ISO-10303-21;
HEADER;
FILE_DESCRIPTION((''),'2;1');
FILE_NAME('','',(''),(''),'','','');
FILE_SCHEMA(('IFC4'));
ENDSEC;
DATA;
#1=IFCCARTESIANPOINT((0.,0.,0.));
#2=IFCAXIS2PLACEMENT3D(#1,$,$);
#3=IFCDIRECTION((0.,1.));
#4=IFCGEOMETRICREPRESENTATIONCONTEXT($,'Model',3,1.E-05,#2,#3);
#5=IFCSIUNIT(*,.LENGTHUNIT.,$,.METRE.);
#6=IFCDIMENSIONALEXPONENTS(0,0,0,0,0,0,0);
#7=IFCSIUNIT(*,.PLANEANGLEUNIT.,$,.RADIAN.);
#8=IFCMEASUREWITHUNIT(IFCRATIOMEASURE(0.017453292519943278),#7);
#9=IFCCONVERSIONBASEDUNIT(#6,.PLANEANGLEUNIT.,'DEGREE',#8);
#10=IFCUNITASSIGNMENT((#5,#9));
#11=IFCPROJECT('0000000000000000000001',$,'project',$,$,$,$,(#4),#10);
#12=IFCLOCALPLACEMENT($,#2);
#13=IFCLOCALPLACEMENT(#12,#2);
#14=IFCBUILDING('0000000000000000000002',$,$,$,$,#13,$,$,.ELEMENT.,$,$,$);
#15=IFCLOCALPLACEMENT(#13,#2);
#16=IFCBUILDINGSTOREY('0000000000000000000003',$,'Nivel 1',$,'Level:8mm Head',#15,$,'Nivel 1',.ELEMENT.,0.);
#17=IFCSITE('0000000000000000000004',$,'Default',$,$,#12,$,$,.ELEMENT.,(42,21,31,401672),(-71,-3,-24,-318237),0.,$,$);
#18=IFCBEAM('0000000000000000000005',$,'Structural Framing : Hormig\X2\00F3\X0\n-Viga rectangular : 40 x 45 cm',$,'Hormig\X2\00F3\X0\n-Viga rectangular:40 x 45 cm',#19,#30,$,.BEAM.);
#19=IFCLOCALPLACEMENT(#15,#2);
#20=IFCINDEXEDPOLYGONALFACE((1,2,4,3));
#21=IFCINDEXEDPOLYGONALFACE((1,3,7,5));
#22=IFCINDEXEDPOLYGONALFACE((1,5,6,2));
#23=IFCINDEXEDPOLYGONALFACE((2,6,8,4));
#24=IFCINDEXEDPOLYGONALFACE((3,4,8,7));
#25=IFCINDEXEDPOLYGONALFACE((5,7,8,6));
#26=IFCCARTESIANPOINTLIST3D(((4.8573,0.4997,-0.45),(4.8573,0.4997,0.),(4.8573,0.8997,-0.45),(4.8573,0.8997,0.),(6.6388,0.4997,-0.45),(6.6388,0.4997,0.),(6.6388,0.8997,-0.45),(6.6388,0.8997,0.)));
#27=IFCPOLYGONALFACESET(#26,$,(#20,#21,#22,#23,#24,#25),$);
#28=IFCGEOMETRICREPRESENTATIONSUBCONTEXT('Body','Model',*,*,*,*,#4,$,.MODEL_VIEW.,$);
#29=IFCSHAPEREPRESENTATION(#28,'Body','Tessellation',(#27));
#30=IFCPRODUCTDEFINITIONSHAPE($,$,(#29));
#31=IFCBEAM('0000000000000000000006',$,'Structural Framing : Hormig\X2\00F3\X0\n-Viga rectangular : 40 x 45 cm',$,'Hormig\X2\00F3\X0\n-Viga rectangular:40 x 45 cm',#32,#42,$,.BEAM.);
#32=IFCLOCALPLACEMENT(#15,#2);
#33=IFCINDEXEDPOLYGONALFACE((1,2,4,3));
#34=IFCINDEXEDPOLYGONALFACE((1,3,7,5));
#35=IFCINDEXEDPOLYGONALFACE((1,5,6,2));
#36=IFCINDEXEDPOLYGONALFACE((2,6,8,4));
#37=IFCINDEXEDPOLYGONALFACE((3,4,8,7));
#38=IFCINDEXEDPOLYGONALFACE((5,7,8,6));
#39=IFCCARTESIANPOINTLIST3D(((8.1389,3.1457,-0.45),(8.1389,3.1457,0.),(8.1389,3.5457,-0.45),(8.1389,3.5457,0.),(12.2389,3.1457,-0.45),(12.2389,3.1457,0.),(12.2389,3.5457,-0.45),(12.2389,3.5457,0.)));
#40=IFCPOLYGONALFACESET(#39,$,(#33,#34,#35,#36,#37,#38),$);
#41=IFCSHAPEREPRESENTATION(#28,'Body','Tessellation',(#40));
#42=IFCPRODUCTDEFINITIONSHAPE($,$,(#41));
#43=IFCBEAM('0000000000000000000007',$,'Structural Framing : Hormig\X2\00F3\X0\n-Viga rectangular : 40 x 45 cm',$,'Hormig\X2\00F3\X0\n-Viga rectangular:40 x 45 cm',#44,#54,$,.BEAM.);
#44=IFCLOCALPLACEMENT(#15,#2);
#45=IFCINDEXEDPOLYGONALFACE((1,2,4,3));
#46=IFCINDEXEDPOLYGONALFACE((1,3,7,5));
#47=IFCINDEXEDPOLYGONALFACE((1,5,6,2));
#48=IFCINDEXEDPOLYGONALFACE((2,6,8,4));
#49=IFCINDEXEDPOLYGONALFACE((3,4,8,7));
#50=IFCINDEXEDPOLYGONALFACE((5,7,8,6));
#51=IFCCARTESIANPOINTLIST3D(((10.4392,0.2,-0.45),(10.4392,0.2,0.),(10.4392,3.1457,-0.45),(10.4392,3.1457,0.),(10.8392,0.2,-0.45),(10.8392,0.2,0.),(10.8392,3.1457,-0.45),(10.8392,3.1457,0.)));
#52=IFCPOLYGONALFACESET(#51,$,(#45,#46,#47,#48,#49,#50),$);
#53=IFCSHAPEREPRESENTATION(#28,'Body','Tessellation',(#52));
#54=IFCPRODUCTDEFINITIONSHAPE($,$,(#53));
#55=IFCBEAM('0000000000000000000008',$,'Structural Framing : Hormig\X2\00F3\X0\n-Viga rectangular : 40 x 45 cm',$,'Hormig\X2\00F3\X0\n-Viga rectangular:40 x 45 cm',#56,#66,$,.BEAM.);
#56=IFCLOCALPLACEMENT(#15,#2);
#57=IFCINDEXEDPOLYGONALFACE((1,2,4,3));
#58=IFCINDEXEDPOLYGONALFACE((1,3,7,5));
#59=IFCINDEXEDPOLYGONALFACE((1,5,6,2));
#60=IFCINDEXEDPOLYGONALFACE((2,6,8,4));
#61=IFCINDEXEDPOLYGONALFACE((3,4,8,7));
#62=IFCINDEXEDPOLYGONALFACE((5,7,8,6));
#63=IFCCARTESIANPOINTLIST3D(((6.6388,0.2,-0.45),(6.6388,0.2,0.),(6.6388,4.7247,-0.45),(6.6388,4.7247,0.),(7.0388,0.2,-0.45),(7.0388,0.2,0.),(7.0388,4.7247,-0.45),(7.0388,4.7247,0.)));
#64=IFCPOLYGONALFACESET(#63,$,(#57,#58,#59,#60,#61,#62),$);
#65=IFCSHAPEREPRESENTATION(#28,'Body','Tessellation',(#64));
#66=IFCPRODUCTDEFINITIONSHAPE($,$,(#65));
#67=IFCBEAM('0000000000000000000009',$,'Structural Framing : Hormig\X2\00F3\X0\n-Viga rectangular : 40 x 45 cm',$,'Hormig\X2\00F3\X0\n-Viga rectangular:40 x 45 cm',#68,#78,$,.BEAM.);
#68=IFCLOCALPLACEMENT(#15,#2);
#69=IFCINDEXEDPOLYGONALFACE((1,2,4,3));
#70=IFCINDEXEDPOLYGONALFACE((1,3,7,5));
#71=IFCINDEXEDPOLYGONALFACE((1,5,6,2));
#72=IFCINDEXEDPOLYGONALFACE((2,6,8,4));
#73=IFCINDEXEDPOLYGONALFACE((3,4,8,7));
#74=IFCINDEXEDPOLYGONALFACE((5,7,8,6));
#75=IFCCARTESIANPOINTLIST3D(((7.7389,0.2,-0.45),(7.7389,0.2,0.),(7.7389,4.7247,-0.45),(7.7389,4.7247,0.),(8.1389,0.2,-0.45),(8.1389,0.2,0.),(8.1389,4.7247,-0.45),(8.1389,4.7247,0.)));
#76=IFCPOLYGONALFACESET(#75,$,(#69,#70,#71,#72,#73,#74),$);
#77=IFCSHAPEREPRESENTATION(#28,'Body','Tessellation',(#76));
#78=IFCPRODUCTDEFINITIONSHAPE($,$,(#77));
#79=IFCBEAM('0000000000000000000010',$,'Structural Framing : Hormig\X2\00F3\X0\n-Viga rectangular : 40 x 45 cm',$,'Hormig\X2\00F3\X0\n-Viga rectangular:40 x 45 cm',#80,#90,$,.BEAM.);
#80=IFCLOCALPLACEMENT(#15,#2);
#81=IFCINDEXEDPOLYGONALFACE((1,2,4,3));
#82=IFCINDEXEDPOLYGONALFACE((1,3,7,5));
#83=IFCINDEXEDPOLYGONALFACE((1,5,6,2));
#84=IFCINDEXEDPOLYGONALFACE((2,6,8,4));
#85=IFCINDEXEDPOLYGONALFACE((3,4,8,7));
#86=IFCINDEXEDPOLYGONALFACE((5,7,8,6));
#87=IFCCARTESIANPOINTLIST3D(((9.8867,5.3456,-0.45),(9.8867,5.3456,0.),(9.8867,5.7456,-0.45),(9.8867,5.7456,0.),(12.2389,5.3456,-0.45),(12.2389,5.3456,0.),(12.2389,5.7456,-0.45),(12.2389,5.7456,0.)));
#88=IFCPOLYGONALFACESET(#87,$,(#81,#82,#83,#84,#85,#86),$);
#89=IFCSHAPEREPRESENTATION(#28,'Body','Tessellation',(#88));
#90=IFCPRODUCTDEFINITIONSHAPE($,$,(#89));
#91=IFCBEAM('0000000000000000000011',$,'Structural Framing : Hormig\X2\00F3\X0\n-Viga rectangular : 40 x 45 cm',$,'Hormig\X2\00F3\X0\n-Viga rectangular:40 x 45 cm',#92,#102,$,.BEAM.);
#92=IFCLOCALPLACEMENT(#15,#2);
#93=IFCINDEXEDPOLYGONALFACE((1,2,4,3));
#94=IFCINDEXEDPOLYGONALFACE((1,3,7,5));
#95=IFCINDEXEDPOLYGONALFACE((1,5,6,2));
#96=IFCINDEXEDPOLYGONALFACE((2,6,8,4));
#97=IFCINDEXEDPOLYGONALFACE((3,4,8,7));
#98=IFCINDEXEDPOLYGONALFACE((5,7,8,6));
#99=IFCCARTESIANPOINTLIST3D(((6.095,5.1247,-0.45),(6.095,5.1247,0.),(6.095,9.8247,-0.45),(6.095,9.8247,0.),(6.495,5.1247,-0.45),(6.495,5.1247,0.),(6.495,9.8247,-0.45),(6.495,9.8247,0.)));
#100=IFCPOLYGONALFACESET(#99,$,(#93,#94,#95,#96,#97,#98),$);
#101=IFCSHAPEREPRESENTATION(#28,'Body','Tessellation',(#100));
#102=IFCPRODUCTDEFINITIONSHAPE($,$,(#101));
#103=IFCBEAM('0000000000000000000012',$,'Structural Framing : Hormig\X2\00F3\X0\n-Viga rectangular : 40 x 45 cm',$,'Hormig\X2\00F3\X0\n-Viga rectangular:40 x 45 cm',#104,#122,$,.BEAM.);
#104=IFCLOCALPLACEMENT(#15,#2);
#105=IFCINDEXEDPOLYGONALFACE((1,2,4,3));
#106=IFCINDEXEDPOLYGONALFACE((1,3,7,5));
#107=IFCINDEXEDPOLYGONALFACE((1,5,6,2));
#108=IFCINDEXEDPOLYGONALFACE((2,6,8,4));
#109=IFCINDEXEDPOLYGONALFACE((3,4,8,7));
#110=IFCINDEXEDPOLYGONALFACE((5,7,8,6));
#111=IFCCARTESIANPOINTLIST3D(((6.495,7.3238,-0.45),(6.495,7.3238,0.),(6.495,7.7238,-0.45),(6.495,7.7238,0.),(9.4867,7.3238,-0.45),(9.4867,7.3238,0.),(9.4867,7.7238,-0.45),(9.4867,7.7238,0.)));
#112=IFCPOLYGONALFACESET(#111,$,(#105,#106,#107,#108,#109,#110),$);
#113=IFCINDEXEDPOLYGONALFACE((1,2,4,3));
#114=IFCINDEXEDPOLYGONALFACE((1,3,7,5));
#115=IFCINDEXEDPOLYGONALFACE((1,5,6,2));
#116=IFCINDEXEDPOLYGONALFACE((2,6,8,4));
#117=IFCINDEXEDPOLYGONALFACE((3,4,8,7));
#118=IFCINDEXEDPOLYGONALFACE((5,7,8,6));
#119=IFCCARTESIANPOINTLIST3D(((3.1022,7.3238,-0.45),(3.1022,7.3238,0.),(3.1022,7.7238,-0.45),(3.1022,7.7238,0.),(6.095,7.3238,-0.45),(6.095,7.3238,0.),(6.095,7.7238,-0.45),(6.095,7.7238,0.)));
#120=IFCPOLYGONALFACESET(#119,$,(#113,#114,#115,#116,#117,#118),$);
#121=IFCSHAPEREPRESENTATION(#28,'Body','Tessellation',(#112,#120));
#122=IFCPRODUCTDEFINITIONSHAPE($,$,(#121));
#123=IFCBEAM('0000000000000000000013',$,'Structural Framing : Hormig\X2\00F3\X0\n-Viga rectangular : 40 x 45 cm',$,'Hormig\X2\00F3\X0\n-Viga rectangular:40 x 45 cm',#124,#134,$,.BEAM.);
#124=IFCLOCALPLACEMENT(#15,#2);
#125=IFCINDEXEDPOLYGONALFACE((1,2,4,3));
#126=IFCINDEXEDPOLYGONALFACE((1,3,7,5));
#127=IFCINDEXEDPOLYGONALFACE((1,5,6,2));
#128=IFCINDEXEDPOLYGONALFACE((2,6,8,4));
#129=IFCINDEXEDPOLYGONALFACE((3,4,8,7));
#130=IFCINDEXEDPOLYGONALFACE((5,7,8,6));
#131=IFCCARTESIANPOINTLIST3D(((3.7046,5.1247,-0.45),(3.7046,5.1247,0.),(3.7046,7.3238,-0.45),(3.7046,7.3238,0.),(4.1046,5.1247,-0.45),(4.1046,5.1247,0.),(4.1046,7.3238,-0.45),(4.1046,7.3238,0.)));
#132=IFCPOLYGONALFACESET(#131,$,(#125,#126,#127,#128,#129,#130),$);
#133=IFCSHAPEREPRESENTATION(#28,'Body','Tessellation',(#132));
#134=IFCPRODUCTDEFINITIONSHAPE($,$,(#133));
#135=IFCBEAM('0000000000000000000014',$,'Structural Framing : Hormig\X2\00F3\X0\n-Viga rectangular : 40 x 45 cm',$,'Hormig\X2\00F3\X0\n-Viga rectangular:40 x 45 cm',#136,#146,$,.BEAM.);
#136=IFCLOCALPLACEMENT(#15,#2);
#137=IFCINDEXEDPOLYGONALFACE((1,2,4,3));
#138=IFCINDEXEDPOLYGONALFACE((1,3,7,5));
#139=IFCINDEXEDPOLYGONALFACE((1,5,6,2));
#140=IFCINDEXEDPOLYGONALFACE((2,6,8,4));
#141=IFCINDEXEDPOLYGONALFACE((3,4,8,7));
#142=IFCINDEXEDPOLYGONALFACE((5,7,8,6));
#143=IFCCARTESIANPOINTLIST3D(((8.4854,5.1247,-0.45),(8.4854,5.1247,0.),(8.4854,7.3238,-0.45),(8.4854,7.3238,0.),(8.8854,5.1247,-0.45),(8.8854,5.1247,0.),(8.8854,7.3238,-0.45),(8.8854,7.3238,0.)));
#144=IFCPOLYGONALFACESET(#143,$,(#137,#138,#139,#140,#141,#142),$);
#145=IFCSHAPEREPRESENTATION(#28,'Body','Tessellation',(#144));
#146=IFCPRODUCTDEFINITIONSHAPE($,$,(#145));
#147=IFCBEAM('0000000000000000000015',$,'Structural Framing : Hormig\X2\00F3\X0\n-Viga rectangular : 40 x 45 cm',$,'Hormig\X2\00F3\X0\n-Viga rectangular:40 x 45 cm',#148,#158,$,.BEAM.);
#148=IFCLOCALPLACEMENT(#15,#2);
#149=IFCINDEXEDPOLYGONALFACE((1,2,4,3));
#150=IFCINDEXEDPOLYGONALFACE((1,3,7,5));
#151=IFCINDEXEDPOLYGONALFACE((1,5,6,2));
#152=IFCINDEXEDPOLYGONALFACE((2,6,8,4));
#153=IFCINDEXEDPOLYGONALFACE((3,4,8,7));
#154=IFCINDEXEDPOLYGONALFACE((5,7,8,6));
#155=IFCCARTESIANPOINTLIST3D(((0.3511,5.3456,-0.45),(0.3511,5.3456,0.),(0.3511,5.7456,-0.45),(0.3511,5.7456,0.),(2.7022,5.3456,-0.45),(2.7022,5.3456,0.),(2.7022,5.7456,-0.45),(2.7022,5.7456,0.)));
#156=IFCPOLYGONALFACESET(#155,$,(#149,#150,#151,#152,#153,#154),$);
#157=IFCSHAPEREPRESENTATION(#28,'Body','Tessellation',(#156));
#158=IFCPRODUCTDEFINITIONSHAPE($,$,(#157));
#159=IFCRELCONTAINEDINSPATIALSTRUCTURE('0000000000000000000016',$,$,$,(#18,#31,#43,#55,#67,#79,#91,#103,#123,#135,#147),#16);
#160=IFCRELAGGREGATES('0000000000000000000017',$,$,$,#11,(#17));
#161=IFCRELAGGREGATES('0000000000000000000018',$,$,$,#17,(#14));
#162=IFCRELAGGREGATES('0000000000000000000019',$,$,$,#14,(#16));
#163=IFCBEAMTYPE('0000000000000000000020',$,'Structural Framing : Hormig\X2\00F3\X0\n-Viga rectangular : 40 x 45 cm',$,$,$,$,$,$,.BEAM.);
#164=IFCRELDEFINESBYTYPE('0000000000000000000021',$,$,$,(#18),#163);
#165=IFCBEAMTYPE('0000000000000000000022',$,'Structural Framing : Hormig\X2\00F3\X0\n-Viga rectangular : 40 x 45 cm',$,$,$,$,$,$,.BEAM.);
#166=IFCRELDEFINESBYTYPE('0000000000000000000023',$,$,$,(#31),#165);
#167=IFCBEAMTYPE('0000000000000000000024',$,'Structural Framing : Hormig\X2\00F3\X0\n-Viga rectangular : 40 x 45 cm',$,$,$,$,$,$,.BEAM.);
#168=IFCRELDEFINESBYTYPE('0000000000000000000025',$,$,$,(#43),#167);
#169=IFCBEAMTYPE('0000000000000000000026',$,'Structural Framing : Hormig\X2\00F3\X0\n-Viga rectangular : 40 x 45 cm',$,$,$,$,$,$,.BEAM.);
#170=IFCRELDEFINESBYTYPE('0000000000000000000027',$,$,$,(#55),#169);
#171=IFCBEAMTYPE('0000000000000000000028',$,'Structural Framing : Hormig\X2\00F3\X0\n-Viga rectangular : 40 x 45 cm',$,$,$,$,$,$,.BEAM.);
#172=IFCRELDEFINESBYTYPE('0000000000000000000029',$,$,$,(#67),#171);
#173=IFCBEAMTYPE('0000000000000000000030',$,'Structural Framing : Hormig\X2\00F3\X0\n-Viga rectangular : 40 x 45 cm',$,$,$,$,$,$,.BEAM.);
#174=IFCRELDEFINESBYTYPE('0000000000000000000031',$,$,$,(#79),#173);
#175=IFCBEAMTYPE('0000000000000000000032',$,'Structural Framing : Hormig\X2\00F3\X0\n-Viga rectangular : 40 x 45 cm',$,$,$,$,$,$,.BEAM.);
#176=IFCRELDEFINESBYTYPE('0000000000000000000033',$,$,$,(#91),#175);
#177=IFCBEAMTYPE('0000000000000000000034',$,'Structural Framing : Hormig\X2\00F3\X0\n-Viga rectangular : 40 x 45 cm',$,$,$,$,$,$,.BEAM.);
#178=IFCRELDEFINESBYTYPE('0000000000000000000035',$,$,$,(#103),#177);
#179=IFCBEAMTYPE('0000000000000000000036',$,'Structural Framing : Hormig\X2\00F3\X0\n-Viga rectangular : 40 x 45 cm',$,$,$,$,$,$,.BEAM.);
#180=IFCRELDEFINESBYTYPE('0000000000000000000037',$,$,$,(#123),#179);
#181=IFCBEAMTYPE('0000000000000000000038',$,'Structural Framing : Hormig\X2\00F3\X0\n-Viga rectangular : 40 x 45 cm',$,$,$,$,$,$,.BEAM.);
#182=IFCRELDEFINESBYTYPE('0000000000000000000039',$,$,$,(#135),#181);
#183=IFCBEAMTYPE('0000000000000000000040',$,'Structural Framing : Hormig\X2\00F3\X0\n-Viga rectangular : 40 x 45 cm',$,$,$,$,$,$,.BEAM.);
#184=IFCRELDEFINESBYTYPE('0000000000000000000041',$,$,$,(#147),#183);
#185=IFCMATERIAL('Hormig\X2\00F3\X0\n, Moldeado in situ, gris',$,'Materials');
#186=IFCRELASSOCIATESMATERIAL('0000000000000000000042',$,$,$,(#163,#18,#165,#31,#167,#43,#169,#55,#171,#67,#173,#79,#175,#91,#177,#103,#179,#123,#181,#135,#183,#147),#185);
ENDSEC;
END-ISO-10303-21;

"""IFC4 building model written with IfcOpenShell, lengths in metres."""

from ifc_helpers import new_model, entity, si_unit, converted_unit, direction, frame, origin, place, context, subcontext, project, spatial, indexed_curve, outline, extrude, source, transform, mapped, material, type_object, type_shapes, element, save


model = new_model("IFC4")

# Units and contexts
model_context = context("Model", 3, precision=1e-05, world=origin(), true_north=direction((0.0, 1.0)))
body_context = subcontext(model_context, "Body", "Model", "MODEL_VIEW")
ifc_project = project(units=[si_unit("LENGTHUNIT", "METRE"), converted_unit("PLANEANGLEUNIT", "DEGREE", entity("IfcRatioMeasure", 0.017453292519943278), si_unit("PLANEANGLEUNIT", "RADIAN"), dimensions=[0, 0, 0, 0, 0, 0, 0])], contexts=[model_context])

# Site, building, storey
site_placement = place(None, origin())
site = spatial("IfcSite", under=ifc_project, at=site_placement, Name="Default", CompositionType="ELEMENT", RefLatitude=(42, 21, 31, 401672), RefLongitude=(-71, -3, -24, -318237), RefElevation=0.0)
building_placement = place(site_placement, origin())
building = spatial("IfcBuilding", under=site, at=building_placement, CompositionType="ELEMENT")
storey_placement = place(building_placement, origin())
storey = spatial("IfcBuildingStorey", under=building, at=storey_placement, Name="Nivel 1", ObjectType="Level:8mm Head", LongName="Nivel 1", CompositionType="ELEMENT", Elevation=0.0)

# Beams
ifc_material_1 = material(Name="Hormigón, Moldeado in situ, gris", Category="Materials")
beam_type_1 = type_object("IfcBeamType", Name="Structural Framing : Hormigón-Viga rectangular : 40 x 45 cm", PredefinedType="BEAM", material=ifc_material_1)
shared_shape_1 = source(origin(), body_context, "Body", "SweptSolid", [
    extrude(outline(indexed_curve([(-0.225, -0.2), (0.225, -0.2), (0.225, 0.2), (-0.225, 0.2), (-0.225, -0.2)], self_intersect=False)), frame((4.8573, 0.6997, -0.225), z_axis=(1.0, 0.0, 0.0), x_axis=(0.0, 0.0, -1.0)), (0.0, 0.0, 1.0), 1.7816),
])
type_shapes(beam_type_1, [shared_shape_1])
beam_1_placement = place(storey_placement, origin())
element("IfcBeam", 1, at=beam_1_placement, inside=storey, type_object=beam_type_1, material=ifc_material_1, Name="Structural Framing : Hormigón-Viga rectangular : 40 x 45 cm", ObjectType="Hormigón-Viga rectangular:40 x 45 cm", PredefinedType="BEAM", context=body_context, shape_type="MappedRepresentation", body=[
    mapped(shared_shape_1, transform((0.0, 0.0, 0.0), scale=1.0)),
])
beam_type_2 = type_object("IfcBeamType", Name="Structural Framing : Hormigón-Viga rectangular : 40 x 45 cm", PredefinedType="BEAM", material=ifc_material_1)
shared_shape_2 = source(origin(), body_context, "Body", "SweptSolid", [
    extrude(outline(indexed_curve([(-0.225, -0.2), (0.225, -0.2), (0.225, 0.2), (-0.225, 0.2), (-0.225, -0.2)], self_intersect=False)), frame((8.1389, 3.3457, -0.225), z_axis=(1.0, 0.0, 0.0), x_axis=(0.0, 0.0, -1.0)), (0.0, 0.0, 1.0), 4.1),
])
type_shapes(beam_type_2, [shared_shape_2])
beam_2_placement = place(storey_placement, origin())
element("IfcBeam", 2, at=beam_2_placement, inside=storey, type_object=beam_type_2, material=ifc_material_1, Name="Structural Framing : Hormigón-Viga rectangular : 40 x 45 cm", ObjectType="Hormigón-Viga rectangular:40 x 45 cm", PredefinedType="BEAM", context=body_context, shape_type="MappedRepresentation", body=[
    mapped(shared_shape_2, transform((0.0, 0.0, 0.0), scale=1.0)),
])
beam_type_3 = type_object("IfcBeamType", Name="Structural Framing : Hormigón-Viga rectangular : 40 x 45 cm", PredefinedType="BEAM", material=ifc_material_1)
shared_shape_3 = source(origin(), body_context, "Body", "SweptSolid", [
    extrude(outline(indexed_curve([(-0.2, -0.225), (0.2, -0.225), (0.2, 0.225), (-0.2, 0.225), (-0.2, -0.225)], self_intersect=False)), frame((10.6392, 3.1457, -0.225), z_axis=(0.0, -1.0, 0.0), x_axis=(-1.0, 0.0, 0.0)), (0.0, 0.0, 1.0), 2.9457),
])
type_shapes(beam_type_3, [shared_shape_3])
beam_3_placement = place(storey_placement, origin())
element("IfcBeam", 3, at=beam_3_placement, inside=storey, type_object=beam_type_3, material=ifc_material_1, Name="Structural Framing : Hormigón-Viga rectangular : 40 x 45 cm", ObjectType="Hormigón-Viga rectangular:40 x 45 cm", PredefinedType="BEAM", context=body_context, shape_type="MappedRepresentation", body=[
    mapped(shared_shape_3, transform((0.0, 0.0, 0.0), scale=1.0)),
])
beam_type_4 = type_object("IfcBeamType", Name="Structural Framing : Hormigón-Viga rectangular : 40 x 45 cm", PredefinedType="BEAM", material=ifc_material_1)
shared_shape_4 = source(origin(), body_context, "Body", "SweptSolid", [
    extrude(outline(indexed_curve([(-0.2, -0.225), (0.2, -0.225), (0.2, 0.225), (-0.2, 0.225), (-0.2, -0.225)], self_intersect=False)), frame((6.8388, 4.7247, -0.225), z_axis=(0.0, -1.0, 0.0), x_axis=(-1.0, 0.0, 0.0)), (0.0, 0.0, 1.0), 4.5247),
])
type_shapes(beam_type_4, [shared_shape_4])
beam_4_placement = place(storey_placement, origin())
element("IfcBeam", 4, at=beam_4_placement, inside=storey, type_object=beam_type_4, material=ifc_material_1, Name="Structural Framing : Hormigón-Viga rectangular : 40 x 45 cm", ObjectType="Hormigón-Viga rectangular:40 x 45 cm", PredefinedType="BEAM", context=body_context, shape_type="MappedRepresentation", body=[
    mapped(shared_shape_4, transform((0.0, 0.0, 0.0), scale=1.0)),
])
beam_type_5 = type_object("IfcBeamType", Name="Structural Framing : Hormigón-Viga rectangular : 40 x 45 cm", PredefinedType="BEAM", material=ifc_material_1)
shared_shape_5 = source(origin(), body_context, "Body", "SweptSolid", [
    extrude(outline(indexed_curve([(-0.2, -0.225), (0.2, -0.225), (0.2, 0.225), (-0.2, 0.225), (-0.2, -0.225)], self_intersect=False)), frame((7.9389, 4.7247, -0.225), z_axis=(0.0, -1.0, 0.0), x_axis=(-1.0, 0.0, 0.0)), (0.0, 0.0, 1.0), 4.5247),
])
type_shapes(beam_type_5, [shared_shape_5])
beam_5_placement = place(storey_placement, origin())
element("IfcBeam", 5, at=beam_5_placement, inside=storey, type_object=beam_type_5, material=ifc_material_1, Name="Structural Framing : Hormigón-Viga rectangular : 40 x 45 cm", ObjectType="Hormigón-Viga rectangular:40 x 45 cm", PredefinedType="BEAM", context=body_context, shape_type="MappedRepresentation", body=[
    mapped(shared_shape_5, transform((0.0, 0.0, 0.0), scale=1.0)),
])
beam_type_6 = type_object("IfcBeamType", Name="Structural Framing : Hormigón-Viga rectangular : 40 x 45 cm", PredefinedType="BEAM", material=ifc_material_1)
shared_shape_6 = source(origin(), body_context, "Body", "SweptSolid", [
    extrude(outline(indexed_curve([(-0.225, -0.2), (0.225, -0.2), (0.225, 0.2), (-0.225, 0.2), (-0.225, -0.2)], self_intersect=False)), frame((9.8867, 5.5456, -0.225), z_axis=(1.0, 0.0, 0.0), x_axis=(0.0, 0.0, -1.0)), (0.0, 0.0, 1.0), 2.3522),
])
type_shapes(beam_type_6, [shared_shape_6])
beam_6_placement = place(storey_placement, origin())
element("IfcBeam", 6, at=beam_6_placement, inside=storey, type_object=beam_type_6, material=ifc_material_1, Name="Structural Framing : Hormigón-Viga rectangular : 40 x 45 cm", ObjectType="Hormigón-Viga rectangular:40 x 45 cm", PredefinedType="BEAM", context=body_context, shape_type="MappedRepresentation", body=[
    mapped(shared_shape_6, transform((0.0, 0.0, 0.0), scale=1.0)),
])
beam_type_7 = type_object("IfcBeamType", Name="Structural Framing : Hormigón-Viga rectangular : 40 x 45 cm", PredefinedType="BEAM", material=ifc_material_1)
shared_shape_7 = source(origin(), body_context, "Body", "SweptSolid", [
    extrude(outline(indexed_curve([(-0.2, -0.225), (0.2, -0.225), (0.2, 0.225), (-0.2, 0.225), (-0.2, -0.225)], self_intersect=False)), frame((6.295, 9.8247, -0.225), z_axis=(0.0, -1.0, 0.0), x_axis=(-1.0, 0.0, 0.0)), (0.0, 0.0, 1.0), 4.7001),
])
type_shapes(beam_type_7, [shared_shape_7])
beam_7_placement = place(storey_placement, origin())
element("IfcBeam", 7, at=beam_7_placement, inside=storey, type_object=beam_type_7, material=ifc_material_1, Name="Structural Framing : Hormigón-Viga rectangular : 40 x 45 cm", ObjectType="Hormigón-Viga rectangular:40 x 45 cm", PredefinedType="BEAM", context=body_context, shape_type="MappedRepresentation", body=[
    mapped(shared_shape_7, transform((0.0, 0.0, 0.0), scale=1.0)),
])
beam_type_8 = type_object("IfcBeamType", Name="Structural Framing : Hormigón-Viga rectangular : 40 x 45 cm", PredefinedType="BEAM", material=ifc_material_1)
shared_shape_8 = source(origin(), body_context, "Body", "SweptSolid", [
    extrude(outline(indexed_curve([(-0.225, -0.2), (0.225, -0.2), (0.225, 0.2), (-0.225, 0.2), (-0.225, -0.2)], self_intersect=False)), frame((6.495, 7.5238, -0.225), z_axis=(1.0, 0.0, 0.0), x_axis=(0.0, 0.0, -1.0)), (0.0, 0.0, 1.0), 2.9917),
    extrude(outline(indexed_curve([(-0.225, -0.2), (0.225, -0.2), (0.225, 0.2), (-0.225, 0.2), (-0.225, -0.2)], self_intersect=False)), frame((3.1022, 7.5238, -0.225), z_axis=(1.0, 0.0, 0.0), x_axis=(0.0, 0.0, -1.0)), (0.0, 0.0, 1.0), 2.9928),
])
type_shapes(beam_type_8, [shared_shape_8])
beam_8_placement = place(storey_placement, origin())
element("IfcBeam", 8, at=beam_8_placement, inside=storey, type_object=beam_type_8, material=ifc_material_1, Name="Structural Framing : Hormigón-Viga rectangular : 40 x 45 cm", ObjectType="Hormigón-Viga rectangular:40 x 45 cm", PredefinedType="BEAM", context=body_context, shape_type="MappedRepresentation", body=[
    mapped(shared_shape_8, transform((0.0, 0.0, 0.0), scale=1.0)),
])
beam_type_9 = type_object("IfcBeamType", Name="Structural Framing : Hormigón-Viga rectangular : 40 x 45 cm", PredefinedType="BEAM", material=ifc_material_1)
shared_shape_9 = source(origin(), body_context, "Body", "SweptSolid", [
    extrude(outline(indexed_curve([(-0.2, -0.225), (0.2, -0.225), (0.2, 0.225), (-0.2, 0.225), (-0.2, -0.225)], self_intersect=False)), frame((3.9046, 7.3238, -0.225), z_axis=(0.0, -1.0, 0.0), x_axis=(-1.0, 0.0, 0.0)), (0.0, 0.0, 1.0), 2.1991),
])
type_shapes(beam_type_9, [shared_shape_9])
beam_9_placement = place(storey_placement, origin())
element("IfcBeam", 9, at=beam_9_placement, inside=storey, type_object=beam_type_9, material=ifc_material_1, Name="Structural Framing : Hormigón-Viga rectangular : 40 x 45 cm", ObjectType="Hormigón-Viga rectangular:40 x 45 cm", PredefinedType="BEAM", context=body_context, shape_type="MappedRepresentation", body=[
    mapped(shared_shape_9, transform((0.0, 0.0, 0.0), scale=1.0)),
])
beam_type_10 = type_object("IfcBeamType", Name="Structural Framing : Hormigón-Viga rectangular : 40 x 45 cm", PredefinedType="BEAM", material=ifc_material_1)
shared_shape_10 = source(origin(), body_context, "Body", "SweptSolid", [
    extrude(outline(indexed_curve([(-0.2, -0.225), (0.2, -0.225), (0.2, 0.225), (-0.2, 0.225), (-0.2, -0.225)], self_intersect=False)), frame((8.6854, 7.3238, -0.225), z_axis=(0.0, -1.0, 0.0), x_axis=(-1.0, 0.0, 0.0)), (0.0, 0.0, 1.0), 2.1991),
])
type_shapes(beam_type_10, [shared_shape_10])
beam_10_placement = place(storey_placement, origin())
element("IfcBeam", 10, at=beam_10_placement, inside=storey, type_object=beam_type_10, material=ifc_material_1, Name="Structural Framing : Hormigón-Viga rectangular : 40 x 45 cm", ObjectType="Hormigón-Viga rectangular:40 x 45 cm", PredefinedType="BEAM", context=body_context, shape_type="MappedRepresentation", body=[
    mapped(shared_shape_10, transform((0.0, 0.0, 0.0), scale=1.0)),
])
beam_type_11 = type_object("IfcBeamType", Name="Structural Framing : Hormigón-Viga rectangular : 40 x 45 cm", PredefinedType="BEAM", material=ifc_material_1)
shared_shape_11 = source(origin(), body_context, "Body", "SweptSolid", [
    extrude(outline(indexed_curve([(-0.225, -0.2), (0.225, -0.2), (0.225, 0.2), (-0.225, 0.2), (-0.225, -0.2)], self_intersect=False)), frame((0.3511, 5.5456, -0.225), z_axis=(1.0, 0.0, 0.0), x_axis=(0.0, 0.0, -1.0)), (0.0, 0.0, 1.0), 2.351),
])
type_shapes(beam_type_11, [shared_shape_11])
beam_11_placement = place(storey_placement, origin())
element("IfcBeam", 11, at=beam_11_placement, inside=storey, type_object=beam_type_11, material=ifc_material_1, Name="Structural Framing : Hormigón-Viga rectangular : 40 x 45 cm", ObjectType="Hormigón-Viga rectangular:40 x 45 cm", PredefinedType="BEAM", context=body_context, shape_type="MappedRepresentation", body=[
    mapped(shared_shape_11, transform((0.0, 0.0, 0.0), scale=1.0)),
])

save(model, "model.ifc")
